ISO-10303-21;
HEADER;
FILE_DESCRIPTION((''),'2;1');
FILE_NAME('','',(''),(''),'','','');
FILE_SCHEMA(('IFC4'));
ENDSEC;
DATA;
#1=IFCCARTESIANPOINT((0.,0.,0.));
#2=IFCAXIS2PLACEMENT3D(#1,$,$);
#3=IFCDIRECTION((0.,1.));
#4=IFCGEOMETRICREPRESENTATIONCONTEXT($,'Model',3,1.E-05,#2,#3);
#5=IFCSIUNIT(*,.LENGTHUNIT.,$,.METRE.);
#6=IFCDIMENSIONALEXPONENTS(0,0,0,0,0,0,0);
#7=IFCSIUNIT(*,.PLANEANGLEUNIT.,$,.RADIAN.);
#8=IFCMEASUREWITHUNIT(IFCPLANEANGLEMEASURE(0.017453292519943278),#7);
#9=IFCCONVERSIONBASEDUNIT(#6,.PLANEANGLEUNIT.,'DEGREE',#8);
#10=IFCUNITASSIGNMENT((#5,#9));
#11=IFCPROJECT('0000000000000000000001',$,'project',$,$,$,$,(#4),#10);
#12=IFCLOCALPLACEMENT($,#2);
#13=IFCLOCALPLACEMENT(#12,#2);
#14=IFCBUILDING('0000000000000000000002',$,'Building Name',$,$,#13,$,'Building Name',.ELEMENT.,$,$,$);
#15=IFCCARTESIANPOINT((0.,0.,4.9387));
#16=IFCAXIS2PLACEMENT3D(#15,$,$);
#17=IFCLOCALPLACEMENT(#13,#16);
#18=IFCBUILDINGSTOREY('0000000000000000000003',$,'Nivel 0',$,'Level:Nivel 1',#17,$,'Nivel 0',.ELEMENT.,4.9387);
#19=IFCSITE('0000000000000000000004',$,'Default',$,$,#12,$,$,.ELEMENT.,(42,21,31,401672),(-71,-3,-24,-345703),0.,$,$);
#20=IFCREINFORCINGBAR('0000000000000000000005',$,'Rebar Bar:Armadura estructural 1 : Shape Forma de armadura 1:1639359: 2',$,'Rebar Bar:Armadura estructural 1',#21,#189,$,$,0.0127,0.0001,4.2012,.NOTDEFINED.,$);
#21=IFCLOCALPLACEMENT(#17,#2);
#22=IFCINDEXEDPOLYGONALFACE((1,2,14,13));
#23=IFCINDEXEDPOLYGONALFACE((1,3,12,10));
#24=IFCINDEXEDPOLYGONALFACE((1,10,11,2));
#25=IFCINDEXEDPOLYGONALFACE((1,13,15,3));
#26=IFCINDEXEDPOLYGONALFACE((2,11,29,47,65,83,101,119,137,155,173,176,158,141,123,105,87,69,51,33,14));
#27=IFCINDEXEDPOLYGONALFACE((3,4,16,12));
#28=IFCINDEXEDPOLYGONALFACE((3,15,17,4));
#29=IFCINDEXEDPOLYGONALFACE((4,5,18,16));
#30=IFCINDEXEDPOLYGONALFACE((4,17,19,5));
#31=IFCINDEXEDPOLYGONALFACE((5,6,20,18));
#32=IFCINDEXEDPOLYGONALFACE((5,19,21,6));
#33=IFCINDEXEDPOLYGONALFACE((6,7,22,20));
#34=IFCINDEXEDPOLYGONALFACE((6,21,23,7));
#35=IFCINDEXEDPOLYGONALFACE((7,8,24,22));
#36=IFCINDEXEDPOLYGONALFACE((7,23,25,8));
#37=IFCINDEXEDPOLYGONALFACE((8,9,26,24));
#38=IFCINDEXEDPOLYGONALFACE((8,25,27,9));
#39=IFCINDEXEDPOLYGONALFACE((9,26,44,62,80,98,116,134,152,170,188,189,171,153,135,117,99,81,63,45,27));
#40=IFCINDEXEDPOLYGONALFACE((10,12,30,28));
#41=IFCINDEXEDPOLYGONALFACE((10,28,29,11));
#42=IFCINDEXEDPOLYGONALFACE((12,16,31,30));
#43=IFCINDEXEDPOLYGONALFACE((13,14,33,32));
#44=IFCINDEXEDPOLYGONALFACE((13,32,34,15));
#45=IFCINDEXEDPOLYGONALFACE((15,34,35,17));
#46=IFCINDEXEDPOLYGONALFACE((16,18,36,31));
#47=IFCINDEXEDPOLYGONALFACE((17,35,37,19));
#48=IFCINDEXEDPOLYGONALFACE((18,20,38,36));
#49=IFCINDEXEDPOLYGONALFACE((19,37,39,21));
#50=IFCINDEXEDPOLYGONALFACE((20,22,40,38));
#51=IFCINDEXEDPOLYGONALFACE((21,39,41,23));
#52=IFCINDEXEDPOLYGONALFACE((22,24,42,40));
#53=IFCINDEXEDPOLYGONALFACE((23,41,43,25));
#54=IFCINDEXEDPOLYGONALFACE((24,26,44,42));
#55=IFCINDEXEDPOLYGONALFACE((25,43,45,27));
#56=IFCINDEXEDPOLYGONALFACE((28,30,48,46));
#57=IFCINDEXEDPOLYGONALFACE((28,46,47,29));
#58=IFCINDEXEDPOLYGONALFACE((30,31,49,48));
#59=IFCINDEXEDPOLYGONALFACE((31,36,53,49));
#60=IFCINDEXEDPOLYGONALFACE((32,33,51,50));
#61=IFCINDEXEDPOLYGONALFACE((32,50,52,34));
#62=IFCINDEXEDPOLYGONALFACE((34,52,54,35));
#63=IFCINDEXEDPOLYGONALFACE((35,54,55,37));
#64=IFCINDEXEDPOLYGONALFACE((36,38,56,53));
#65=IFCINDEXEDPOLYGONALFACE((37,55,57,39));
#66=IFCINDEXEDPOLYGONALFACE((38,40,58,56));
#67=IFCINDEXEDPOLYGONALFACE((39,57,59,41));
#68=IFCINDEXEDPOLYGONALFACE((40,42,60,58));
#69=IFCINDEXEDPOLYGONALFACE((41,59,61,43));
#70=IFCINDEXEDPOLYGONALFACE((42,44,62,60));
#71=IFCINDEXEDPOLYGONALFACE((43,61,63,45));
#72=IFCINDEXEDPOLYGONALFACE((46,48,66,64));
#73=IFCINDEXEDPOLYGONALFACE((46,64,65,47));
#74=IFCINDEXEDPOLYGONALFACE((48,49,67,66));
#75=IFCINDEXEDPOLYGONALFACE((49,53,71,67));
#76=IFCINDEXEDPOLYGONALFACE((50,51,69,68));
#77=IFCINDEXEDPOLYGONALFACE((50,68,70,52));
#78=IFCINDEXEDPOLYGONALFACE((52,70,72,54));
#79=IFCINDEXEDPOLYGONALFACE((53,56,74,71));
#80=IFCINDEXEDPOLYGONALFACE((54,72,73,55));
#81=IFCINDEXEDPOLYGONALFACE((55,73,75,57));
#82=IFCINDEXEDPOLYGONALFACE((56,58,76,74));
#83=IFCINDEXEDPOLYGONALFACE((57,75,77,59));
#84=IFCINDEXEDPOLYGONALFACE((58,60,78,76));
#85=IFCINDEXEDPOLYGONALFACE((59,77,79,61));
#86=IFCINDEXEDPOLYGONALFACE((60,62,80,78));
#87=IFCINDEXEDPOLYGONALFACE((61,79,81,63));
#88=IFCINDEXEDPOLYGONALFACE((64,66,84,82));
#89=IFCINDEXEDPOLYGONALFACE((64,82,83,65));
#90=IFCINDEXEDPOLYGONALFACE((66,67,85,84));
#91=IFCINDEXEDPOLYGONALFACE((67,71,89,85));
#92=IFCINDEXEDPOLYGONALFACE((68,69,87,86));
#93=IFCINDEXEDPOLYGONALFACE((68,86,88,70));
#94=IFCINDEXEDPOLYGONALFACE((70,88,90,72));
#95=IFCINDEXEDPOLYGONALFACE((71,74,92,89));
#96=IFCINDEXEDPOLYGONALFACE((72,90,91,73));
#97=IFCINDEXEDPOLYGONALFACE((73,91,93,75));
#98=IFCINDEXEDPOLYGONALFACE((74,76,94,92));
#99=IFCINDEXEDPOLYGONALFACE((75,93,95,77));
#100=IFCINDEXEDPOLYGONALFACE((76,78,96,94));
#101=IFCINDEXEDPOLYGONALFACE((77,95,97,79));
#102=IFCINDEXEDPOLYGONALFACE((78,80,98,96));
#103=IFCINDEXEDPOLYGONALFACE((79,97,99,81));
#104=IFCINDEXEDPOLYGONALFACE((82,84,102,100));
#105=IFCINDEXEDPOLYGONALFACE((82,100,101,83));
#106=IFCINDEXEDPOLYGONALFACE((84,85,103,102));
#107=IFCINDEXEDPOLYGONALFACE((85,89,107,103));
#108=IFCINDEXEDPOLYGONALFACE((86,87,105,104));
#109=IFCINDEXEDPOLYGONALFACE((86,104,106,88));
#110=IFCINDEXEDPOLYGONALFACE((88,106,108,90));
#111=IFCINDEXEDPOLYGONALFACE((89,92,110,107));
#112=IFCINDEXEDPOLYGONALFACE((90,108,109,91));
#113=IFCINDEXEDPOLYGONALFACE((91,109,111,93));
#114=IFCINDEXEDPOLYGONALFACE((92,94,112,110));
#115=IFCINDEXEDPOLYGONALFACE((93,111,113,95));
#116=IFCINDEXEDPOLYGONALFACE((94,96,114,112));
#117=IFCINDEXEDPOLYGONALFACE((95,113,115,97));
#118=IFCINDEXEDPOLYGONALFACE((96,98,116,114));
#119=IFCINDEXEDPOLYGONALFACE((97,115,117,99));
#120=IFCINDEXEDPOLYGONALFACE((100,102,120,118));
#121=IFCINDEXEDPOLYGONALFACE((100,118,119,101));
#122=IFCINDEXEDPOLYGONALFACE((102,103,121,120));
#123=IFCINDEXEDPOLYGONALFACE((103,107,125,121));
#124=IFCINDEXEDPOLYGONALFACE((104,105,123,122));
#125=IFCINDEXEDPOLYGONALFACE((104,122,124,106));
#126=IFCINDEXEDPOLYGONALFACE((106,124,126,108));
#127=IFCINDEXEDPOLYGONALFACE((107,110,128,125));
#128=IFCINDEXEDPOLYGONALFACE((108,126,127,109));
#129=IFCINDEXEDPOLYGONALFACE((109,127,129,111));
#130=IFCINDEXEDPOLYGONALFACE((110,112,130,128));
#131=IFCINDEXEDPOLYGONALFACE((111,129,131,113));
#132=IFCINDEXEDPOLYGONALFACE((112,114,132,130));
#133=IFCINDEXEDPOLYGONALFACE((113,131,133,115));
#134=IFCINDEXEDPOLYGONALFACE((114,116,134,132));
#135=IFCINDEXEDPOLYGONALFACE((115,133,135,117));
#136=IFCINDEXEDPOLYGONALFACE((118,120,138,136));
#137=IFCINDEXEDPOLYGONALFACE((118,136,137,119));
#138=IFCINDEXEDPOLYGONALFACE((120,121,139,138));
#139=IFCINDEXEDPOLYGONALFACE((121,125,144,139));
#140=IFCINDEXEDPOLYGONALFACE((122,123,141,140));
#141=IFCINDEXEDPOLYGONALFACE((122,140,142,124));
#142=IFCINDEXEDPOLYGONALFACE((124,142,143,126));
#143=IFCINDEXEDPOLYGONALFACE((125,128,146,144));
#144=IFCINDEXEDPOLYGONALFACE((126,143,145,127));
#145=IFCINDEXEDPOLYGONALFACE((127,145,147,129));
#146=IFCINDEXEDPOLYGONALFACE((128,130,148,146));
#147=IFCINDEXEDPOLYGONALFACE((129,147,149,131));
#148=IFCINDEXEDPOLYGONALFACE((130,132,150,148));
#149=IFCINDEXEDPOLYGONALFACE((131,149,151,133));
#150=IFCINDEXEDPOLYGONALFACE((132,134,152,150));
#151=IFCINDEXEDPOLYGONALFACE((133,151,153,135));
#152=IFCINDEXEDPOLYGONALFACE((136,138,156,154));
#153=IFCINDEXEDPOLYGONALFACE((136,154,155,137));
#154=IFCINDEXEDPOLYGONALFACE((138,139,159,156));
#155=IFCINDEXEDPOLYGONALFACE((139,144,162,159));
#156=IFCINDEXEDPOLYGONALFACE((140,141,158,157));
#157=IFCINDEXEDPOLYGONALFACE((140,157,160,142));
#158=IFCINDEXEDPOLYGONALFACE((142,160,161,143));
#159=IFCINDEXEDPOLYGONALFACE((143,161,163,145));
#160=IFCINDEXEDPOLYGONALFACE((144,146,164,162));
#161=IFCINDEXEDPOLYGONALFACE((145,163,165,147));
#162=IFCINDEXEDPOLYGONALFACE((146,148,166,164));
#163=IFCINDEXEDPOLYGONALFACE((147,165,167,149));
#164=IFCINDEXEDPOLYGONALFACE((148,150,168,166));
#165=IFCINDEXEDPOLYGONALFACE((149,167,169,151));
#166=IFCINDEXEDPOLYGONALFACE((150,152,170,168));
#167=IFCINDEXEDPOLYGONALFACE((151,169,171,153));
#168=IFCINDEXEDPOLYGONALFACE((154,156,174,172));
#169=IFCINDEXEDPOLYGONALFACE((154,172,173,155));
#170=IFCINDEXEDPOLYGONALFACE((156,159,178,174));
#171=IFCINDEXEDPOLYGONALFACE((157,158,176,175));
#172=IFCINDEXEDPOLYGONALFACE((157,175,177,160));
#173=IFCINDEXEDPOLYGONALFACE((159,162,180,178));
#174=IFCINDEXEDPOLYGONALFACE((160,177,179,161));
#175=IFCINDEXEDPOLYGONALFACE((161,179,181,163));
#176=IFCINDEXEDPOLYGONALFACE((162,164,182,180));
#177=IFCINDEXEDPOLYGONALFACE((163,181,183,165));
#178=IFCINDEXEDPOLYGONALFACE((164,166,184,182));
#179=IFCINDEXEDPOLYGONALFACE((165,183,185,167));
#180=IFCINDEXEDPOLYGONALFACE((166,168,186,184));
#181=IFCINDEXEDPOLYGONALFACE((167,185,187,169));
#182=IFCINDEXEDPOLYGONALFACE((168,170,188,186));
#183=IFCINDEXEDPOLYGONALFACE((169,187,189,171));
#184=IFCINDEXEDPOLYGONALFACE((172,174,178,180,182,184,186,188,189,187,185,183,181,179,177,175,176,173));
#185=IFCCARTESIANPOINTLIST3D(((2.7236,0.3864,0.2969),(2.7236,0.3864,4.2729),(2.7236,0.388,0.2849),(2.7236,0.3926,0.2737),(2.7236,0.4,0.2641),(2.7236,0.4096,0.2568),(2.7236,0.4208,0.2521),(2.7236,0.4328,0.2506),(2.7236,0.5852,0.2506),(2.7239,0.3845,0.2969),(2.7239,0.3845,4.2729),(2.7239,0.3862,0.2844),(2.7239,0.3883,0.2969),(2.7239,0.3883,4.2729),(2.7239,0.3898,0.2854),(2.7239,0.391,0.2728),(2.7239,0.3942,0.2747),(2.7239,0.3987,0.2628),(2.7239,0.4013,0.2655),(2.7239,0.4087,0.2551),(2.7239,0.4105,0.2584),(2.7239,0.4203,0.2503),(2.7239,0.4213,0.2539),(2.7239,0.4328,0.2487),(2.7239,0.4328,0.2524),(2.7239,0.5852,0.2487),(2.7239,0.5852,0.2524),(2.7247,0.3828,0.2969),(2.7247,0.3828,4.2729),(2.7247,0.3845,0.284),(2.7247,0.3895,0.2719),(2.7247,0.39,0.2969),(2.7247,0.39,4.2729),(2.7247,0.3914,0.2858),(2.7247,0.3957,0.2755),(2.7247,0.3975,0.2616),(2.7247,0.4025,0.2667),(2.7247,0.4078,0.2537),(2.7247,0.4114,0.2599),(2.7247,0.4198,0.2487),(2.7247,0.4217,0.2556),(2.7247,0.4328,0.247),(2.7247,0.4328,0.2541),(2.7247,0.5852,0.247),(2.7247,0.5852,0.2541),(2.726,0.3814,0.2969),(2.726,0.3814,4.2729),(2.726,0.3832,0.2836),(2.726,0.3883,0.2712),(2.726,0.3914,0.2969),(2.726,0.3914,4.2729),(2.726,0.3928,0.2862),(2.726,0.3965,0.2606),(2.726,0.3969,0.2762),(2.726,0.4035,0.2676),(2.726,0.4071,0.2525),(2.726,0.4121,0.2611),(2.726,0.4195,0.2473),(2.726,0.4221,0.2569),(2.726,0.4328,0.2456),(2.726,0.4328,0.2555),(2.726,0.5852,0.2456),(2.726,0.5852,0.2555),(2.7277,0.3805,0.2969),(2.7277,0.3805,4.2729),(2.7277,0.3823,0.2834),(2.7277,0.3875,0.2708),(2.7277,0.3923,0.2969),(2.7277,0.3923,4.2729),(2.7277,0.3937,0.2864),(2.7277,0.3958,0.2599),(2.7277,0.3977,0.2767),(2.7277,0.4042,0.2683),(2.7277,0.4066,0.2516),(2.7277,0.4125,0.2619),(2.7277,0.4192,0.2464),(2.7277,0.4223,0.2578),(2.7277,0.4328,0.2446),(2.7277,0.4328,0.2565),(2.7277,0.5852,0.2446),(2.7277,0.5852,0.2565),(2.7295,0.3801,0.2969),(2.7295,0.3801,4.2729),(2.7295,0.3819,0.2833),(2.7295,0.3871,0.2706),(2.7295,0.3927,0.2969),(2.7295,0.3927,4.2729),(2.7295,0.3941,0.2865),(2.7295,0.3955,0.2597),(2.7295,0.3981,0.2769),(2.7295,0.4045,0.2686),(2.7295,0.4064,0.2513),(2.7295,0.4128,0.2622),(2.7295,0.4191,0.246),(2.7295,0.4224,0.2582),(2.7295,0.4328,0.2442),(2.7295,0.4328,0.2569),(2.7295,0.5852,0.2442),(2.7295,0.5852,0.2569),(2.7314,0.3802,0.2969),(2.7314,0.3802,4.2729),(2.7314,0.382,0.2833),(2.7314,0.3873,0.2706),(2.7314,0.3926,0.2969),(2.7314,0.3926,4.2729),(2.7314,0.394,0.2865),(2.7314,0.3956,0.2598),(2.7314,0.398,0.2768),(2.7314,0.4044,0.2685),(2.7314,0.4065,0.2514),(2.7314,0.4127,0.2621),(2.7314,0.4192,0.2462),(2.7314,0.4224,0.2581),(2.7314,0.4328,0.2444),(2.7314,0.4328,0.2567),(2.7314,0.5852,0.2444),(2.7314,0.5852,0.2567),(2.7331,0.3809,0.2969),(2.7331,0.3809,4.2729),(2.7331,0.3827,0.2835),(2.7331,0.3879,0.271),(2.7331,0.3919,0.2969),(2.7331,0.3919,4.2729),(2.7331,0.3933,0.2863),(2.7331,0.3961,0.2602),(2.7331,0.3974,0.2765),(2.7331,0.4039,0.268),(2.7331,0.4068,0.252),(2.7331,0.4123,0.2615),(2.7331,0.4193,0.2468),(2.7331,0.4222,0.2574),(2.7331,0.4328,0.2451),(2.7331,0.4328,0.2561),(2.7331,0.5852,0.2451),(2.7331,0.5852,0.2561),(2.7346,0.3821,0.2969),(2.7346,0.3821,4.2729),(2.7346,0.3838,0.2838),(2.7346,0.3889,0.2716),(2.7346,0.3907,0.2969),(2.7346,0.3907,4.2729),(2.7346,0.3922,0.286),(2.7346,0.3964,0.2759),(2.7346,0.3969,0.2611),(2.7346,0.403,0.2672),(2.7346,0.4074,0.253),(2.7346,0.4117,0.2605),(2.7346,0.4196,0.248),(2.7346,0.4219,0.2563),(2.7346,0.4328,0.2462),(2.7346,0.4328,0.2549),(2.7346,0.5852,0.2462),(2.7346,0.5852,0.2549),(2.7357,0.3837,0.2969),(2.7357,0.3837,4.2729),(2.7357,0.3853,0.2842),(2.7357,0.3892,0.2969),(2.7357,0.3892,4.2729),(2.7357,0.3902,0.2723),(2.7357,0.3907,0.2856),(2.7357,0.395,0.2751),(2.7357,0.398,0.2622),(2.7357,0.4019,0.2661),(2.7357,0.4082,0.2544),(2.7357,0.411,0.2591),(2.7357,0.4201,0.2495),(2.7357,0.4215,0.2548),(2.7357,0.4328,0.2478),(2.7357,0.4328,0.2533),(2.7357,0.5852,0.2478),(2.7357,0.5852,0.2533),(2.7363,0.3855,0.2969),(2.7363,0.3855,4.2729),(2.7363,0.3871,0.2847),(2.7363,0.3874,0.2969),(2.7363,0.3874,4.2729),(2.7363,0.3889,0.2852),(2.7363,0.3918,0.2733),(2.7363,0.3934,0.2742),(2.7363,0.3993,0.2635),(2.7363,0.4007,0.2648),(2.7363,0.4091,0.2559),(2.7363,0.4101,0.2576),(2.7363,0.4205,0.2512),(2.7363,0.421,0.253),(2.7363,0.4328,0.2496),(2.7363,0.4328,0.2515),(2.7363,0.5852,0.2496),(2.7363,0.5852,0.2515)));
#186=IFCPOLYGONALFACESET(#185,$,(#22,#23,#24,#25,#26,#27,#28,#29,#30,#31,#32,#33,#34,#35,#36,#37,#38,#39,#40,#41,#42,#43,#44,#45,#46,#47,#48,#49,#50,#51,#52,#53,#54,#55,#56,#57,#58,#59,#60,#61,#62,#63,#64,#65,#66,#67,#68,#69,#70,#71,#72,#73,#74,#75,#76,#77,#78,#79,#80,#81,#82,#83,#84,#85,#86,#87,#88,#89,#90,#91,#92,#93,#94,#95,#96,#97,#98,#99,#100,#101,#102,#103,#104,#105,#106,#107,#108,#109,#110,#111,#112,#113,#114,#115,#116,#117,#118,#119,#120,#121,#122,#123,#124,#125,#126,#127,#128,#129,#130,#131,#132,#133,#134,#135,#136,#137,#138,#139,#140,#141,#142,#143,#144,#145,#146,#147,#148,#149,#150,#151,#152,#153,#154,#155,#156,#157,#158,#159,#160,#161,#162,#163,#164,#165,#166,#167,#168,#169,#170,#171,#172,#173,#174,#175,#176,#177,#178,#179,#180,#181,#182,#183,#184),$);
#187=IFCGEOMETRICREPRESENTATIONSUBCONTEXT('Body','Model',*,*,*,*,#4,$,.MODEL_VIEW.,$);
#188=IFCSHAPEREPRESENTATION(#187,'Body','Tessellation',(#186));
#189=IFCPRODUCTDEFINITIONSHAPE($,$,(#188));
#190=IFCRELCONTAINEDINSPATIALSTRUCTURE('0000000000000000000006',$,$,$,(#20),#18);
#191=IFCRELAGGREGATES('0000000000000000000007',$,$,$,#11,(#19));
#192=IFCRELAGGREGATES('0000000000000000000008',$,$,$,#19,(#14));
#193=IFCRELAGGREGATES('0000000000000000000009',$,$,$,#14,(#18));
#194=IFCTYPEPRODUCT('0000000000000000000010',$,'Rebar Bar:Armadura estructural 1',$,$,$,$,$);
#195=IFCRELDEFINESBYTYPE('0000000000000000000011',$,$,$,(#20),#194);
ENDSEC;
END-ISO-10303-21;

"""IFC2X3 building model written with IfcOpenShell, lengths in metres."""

from ifc_helpers import new_model, entity, si_unit, converted_unit, direction, frame, origin, place, context, subcontext, project, spatial, type_object, element, save


model = new_model("IFC2X3")

# Units and contexts
model_context = context("Model", 3, precision=1e-05, world=origin(), true_north=direction((0.0, 1.0)))
body_context = subcontext(model_context, "Body", "Model", "MODEL_VIEW")
ifc_project = project(units=[si_unit("LENGTHUNIT", "METRE"), converted_unit("PLANEANGLEUNIT", "DEGREE", entity("IfcPlaneAngleMeasure", 0.017453292519943278), si_unit("PLANEANGLEUNIT", "RADIAN"), dimensions=[0, 0, 0, 0, 0, 0, 0])], contexts=[model_context])

# Site, building, storey
site_placement = place(None, origin())
site = spatial("IfcSite", under=ifc_project, at=site_placement, Name="Default", CompositionType="ELEMENT", RefLatitude=(42, 21, 31, 401672), RefLongitude=(-71, -3, -24, -345703), RefElevation=0.0)
building_placement = place(site_placement, origin())
building = spatial("IfcBuilding", under=site, at=building_placement, Name="Building Name", LongName="Building Name", CompositionType="ELEMENT")
storey_placement = place(building_placement, frame((0.0, 0.0, 4.9387)))
storey = spatial("IfcBuildingStorey", under=building, at=storey_placement, Name="Nivel 0", ObjectType="Level:Nivel 1", LongName="Nivel 0", CompositionType="ELEMENT", Elevation=4.9387)

# Reinforcing bar
type_product = type_object("IfcTypeProduct", Name="Rebar Bar:Armadura estructural 1")
reinforcing_bar_1_placement = place(storey_placement, origin())
element("IfcReinforcingBar", 1, at=reinforcing_bar_1_placement, inside=storey, type_object=type_product, Name="Rebar Bar:Armadura estructural 1 : Shape Forma de armadura 1:1639359: 2", ObjectType="Rebar Bar:Armadura estructural 1", BarLength=4.2012, BarRole="NOTDEFINED", CrossSectionArea=0.0001, NominalDiameter=0.0127, context=body_context, shape_type="AdvancedSweptSolid", body=[
    entity("IfcSweptDiskSolid", entity("IfcCompositeCurve", [entity("IfcCompositeCurveSegment", "CONTINUOUS", True, entity("IfcPolyline", [entity("IfcCartesianPoint", [2.73, 0.5852, 0.2506]), entity("IfcCartesianPoint", [2.73, 0.4328, 0.2506])])), entity("IfcCompositeCurveSegment", "CONTINUOUS", True, entity("IfcTrimmedCurve", entity("IfcCircle", entity("IfcAxis2Placement3D", entity("IfcCartesianPoint", [2.73, 0.4328, 0.2969]), entity("IfcDirection", [-1.0, 0.0, 0.0]), entity("IfcDirection", [0.0, -1.0, 0.0])), 0.0464), [entity("IfcParameterValue", 270.0)], [entity("IfcParameterValue", 360.0)], True, "PARAMETER")), entity("IfcCompositeCurveSegment", "CONTINUOUS", True, entity("IfcPolyline", [entity("IfcCartesianPoint", [2.73, 0.3864, 0.2969]), entity("IfcCartesianPoint", [2.73, 0.3864, 4.2729])]))], False), 0.0063, None, 0.0, 92.0),
])

save(model, "model.ifc")
